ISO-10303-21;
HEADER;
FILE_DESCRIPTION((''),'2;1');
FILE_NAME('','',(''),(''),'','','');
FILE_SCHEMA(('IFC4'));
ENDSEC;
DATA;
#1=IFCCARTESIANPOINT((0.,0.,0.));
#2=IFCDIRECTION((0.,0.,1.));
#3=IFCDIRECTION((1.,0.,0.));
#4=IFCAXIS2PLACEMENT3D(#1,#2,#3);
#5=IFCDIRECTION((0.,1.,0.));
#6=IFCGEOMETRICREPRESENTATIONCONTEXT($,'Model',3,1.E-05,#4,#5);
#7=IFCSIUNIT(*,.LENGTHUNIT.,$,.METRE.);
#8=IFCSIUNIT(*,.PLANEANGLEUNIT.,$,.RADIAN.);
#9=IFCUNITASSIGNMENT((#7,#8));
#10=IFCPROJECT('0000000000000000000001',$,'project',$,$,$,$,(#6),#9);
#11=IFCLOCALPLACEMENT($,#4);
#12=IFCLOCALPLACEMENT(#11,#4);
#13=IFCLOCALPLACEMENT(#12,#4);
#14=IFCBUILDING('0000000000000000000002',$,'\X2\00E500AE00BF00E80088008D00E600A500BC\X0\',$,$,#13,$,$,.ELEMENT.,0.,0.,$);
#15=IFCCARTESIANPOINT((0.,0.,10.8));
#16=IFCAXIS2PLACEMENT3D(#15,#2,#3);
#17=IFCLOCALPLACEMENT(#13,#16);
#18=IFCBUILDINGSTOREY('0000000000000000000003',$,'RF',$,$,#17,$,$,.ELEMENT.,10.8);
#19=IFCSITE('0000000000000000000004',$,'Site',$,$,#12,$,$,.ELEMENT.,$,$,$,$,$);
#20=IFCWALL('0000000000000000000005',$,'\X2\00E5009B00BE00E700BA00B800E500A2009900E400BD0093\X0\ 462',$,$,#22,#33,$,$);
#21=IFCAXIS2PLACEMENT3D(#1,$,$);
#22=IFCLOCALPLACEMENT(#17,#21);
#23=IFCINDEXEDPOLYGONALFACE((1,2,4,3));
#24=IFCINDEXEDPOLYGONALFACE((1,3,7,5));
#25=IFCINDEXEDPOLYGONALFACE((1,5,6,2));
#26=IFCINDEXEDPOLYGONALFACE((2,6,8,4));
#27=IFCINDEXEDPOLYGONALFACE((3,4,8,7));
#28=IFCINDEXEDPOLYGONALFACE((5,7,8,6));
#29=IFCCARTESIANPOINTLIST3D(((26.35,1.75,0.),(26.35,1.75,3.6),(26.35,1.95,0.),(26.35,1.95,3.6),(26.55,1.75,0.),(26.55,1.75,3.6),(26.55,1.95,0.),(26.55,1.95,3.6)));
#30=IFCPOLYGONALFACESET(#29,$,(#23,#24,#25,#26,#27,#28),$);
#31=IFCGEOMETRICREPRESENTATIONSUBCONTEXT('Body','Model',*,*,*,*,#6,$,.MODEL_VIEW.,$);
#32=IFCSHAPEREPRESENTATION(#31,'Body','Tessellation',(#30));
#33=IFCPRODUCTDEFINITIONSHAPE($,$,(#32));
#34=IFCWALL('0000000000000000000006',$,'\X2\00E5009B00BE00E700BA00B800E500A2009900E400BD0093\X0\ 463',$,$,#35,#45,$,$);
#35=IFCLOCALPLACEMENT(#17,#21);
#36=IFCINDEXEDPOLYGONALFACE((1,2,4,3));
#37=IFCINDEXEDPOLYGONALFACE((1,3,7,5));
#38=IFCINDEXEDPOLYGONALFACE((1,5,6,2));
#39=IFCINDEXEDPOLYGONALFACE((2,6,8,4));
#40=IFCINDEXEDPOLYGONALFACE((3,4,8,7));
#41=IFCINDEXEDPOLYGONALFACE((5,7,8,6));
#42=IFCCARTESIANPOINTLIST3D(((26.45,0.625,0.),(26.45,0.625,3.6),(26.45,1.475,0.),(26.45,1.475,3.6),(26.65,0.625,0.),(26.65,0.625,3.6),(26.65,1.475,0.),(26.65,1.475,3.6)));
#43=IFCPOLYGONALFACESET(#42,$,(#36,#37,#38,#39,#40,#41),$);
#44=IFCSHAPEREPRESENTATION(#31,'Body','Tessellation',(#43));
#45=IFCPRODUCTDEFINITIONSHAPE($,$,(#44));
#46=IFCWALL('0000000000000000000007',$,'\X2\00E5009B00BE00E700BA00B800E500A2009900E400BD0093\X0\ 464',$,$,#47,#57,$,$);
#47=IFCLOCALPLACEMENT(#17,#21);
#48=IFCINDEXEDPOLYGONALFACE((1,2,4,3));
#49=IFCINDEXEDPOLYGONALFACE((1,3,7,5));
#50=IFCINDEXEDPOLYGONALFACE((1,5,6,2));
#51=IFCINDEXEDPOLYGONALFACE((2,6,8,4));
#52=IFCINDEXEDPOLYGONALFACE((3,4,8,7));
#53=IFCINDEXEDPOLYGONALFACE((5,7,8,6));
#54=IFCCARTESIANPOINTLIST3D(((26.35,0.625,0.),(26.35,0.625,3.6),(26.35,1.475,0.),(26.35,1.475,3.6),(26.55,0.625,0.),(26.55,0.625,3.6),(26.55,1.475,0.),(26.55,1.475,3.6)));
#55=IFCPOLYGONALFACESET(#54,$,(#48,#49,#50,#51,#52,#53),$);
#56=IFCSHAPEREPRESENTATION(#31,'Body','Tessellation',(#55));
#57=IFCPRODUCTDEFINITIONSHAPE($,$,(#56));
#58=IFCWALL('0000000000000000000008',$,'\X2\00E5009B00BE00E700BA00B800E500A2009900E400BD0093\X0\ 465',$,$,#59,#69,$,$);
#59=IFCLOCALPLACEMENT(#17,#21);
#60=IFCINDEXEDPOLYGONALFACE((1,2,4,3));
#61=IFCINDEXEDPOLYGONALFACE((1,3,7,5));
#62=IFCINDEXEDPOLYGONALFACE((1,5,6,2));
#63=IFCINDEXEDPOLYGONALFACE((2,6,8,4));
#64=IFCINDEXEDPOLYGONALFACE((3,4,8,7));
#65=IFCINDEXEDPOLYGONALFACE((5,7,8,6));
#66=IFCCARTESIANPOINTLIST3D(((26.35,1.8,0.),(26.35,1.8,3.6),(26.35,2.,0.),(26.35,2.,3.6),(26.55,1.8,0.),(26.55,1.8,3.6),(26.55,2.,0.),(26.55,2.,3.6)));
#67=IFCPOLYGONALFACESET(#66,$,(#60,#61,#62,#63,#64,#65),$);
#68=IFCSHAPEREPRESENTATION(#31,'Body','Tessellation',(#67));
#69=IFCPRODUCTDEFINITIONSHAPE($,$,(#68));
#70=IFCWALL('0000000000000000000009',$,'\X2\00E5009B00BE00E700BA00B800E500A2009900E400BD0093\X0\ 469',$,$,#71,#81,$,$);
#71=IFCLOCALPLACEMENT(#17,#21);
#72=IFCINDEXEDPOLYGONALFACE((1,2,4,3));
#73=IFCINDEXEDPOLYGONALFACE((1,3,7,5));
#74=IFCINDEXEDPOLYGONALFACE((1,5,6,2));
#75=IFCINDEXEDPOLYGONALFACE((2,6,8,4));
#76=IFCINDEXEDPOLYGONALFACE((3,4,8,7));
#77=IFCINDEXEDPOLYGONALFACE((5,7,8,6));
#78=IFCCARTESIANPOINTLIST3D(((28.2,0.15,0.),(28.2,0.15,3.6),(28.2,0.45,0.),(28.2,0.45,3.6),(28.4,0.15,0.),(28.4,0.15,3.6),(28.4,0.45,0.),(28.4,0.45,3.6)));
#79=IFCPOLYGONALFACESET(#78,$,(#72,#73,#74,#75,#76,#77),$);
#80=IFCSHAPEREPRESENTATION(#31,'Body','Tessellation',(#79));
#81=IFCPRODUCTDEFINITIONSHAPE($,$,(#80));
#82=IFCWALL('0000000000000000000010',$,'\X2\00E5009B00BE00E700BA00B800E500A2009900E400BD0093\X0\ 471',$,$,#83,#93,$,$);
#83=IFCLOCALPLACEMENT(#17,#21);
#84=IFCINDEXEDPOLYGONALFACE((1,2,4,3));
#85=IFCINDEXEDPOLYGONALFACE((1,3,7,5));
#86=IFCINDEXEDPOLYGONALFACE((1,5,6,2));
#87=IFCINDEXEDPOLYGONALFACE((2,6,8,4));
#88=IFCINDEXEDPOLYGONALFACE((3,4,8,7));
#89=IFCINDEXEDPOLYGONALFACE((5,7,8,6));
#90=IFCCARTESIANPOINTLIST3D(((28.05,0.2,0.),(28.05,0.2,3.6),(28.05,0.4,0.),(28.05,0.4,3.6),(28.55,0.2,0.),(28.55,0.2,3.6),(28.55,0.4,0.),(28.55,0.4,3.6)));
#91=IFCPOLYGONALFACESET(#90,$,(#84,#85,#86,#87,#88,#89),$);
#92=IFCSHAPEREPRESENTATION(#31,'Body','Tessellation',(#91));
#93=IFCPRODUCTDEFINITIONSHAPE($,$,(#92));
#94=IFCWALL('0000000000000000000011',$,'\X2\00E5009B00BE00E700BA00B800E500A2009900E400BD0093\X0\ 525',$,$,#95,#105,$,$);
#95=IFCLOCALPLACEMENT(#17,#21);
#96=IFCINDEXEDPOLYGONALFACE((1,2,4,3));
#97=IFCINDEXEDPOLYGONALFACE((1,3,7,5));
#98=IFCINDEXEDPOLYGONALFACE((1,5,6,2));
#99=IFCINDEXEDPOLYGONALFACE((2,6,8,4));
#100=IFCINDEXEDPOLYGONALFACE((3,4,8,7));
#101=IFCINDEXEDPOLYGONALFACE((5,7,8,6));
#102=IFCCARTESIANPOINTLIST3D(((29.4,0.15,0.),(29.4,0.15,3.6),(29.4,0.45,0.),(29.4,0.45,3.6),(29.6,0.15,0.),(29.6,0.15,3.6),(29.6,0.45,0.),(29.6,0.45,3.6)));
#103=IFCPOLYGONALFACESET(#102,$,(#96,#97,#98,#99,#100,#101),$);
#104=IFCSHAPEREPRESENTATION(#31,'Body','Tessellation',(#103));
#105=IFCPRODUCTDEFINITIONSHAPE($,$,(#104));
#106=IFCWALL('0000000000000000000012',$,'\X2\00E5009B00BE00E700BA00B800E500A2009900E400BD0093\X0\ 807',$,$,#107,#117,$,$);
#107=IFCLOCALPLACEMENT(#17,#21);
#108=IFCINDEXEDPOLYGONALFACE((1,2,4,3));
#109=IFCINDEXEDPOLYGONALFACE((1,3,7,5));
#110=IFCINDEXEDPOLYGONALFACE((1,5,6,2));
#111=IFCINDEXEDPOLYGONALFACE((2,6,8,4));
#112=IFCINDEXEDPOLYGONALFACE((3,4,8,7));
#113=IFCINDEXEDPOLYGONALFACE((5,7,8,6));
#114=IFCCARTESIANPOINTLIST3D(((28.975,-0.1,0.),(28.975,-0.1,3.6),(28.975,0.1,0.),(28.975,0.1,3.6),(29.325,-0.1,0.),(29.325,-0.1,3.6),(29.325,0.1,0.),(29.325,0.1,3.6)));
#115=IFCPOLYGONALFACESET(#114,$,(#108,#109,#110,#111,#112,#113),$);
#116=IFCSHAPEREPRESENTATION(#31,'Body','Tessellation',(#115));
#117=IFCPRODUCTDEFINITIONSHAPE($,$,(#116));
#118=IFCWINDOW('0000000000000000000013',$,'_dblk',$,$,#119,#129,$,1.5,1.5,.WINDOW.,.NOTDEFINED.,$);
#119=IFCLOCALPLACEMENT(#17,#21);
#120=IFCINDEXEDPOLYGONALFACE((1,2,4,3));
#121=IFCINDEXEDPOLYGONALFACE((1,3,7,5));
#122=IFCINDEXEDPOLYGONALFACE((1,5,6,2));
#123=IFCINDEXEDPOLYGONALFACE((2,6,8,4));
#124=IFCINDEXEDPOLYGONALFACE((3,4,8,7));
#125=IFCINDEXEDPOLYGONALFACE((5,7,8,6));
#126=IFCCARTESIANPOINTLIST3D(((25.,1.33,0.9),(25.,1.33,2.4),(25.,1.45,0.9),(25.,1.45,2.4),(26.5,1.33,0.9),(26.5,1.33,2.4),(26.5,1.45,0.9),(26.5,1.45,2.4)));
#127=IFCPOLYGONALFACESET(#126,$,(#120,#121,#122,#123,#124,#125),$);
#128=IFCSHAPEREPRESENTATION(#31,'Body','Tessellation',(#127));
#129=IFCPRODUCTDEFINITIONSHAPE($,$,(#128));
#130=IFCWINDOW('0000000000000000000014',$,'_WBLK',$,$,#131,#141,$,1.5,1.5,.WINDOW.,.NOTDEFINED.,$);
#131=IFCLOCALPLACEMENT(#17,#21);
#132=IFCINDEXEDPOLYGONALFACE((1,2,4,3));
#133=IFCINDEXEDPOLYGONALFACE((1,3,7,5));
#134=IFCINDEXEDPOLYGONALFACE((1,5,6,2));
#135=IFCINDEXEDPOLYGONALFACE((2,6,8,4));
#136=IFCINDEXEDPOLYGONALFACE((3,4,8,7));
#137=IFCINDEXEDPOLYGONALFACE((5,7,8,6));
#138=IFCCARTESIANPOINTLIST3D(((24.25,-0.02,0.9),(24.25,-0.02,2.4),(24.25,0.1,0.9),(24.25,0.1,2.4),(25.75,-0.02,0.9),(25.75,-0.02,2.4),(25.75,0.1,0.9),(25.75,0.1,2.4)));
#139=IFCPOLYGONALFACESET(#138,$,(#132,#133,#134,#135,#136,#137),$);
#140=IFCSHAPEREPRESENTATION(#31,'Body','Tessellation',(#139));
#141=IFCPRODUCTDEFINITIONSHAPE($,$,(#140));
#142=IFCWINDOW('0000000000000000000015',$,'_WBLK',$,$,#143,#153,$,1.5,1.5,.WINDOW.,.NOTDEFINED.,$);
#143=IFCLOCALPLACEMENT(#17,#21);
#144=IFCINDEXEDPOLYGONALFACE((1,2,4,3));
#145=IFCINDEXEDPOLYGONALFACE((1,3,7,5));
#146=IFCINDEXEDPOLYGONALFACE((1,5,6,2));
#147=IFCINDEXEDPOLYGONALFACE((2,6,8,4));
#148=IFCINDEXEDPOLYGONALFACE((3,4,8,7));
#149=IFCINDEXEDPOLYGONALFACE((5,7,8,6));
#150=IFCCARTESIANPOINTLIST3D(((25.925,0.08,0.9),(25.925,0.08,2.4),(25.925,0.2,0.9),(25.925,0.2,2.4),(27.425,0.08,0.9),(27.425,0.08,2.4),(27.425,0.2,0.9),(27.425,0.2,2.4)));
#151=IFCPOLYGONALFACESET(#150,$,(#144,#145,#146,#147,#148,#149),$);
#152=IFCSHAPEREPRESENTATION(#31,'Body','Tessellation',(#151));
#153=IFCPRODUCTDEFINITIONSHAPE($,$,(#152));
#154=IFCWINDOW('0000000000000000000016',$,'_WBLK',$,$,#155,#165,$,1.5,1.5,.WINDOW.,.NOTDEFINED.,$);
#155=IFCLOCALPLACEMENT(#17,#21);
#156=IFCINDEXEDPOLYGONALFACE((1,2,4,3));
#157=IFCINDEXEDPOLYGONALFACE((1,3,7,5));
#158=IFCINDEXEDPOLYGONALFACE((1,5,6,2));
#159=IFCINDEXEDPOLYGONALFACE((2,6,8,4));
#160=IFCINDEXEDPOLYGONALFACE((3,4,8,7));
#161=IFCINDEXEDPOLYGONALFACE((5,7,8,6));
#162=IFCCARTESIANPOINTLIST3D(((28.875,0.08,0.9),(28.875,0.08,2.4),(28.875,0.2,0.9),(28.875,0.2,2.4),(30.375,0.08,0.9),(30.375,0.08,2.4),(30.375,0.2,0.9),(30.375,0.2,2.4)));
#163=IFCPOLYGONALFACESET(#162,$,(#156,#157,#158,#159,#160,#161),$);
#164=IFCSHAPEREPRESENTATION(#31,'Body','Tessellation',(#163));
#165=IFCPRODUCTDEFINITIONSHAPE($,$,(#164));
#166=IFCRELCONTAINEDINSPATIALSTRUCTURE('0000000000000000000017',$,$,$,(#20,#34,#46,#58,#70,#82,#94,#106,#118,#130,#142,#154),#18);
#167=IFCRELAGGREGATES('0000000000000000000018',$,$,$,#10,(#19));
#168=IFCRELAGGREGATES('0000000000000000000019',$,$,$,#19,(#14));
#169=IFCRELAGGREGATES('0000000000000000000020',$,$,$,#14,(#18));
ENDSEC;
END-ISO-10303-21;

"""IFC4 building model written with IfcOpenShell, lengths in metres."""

from ifc_helpers import new_model, si_unit, direction, frame, frame_2d, origin_with_axes, place, context, subcontext, project, spatial, rectangle, extrude, element, save


model = new_model("IFC4")

# Units and contexts
model_context = context("Model", 3, precision=1e-05, world=origin_with_axes(), true_north=direction((0.0, 1.0, 0.0)))
body_context = subcontext(model_context, "Body", "Model", "MODEL_VIEW")
ifc_project = project(units=[si_unit("LENGTHUNIT", "METRE"), si_unit("PLANEANGLEUNIT", "RADIAN")], contexts=[model_context])

# Site, building, storey
placement = place(None, origin_with_axes())
site_placement = place(placement, origin_with_axes())
site = spatial("IfcSite", under=ifc_project, at=site_placement, Name="Site", CompositionType="ELEMENT")
building_placement = place(site_placement, origin_with_axes())
building = spatial("IfcBuilding", under=site, at=building_placement, Name="å®¿è\u0088\u008dæ¥¼", CompositionType="ELEMENT", ElevationOfRefHeight=0.0, ElevationOfTerrain=0.0)
storey_placement = place(building_placement, frame((0.0, 0.0, 10.8), z_axis=(0.0, 0.0, 1.0), x_axis=(1.0, 0.0, 0.0)))
storey = spatial("IfcBuildingStorey", under=building, at=storey_placement, Name="RF", CompositionType="ELEMENT", Elevation=10.8)

# Walls
for number, where, z_axis, x_axis, name in (
    (1, (26.45, 1.85, 0.0), (0.0, 0.0, 1.0), (1.0, 0.0, 0.0), "å\u009b¾çº¸å¢\u0099ä½\u0093 462"),
):
    element("IfcWall", number, at=place(storey_placement, frame(where, z_axis=z_axis, x_axis=x_axis)), inside=storey, Name=name, context=body_context, shape_type="SweptSolid", body=[
        extrude(rectangle(XDim=0.2, YDim=0.2, at=frame_2d((0.0, 0.0), x_axis=(1.0, 0.0, 0.0))), frame((0.0, 0.0, 0.0), z_axis=(0.0, 0.0, 1.0)), (0.0, 0.0, 1.0), 3.6),
    ])
for number, where, z_axis, x_axis, name in (
    (2, (26.55, 1.05, 0.0), (0.0, 0.0, 1.0), (0.0, -1.0, 0.0), "å\u009b¾çº¸å¢\u0099ä½\u0093 463"),
    (3, (26.45, 1.05, 0.0), (0.0, 0.0, 1.0), (0.0, -1.0, 0.0), "å\u009b¾çº¸å¢\u0099ä½\u0093 464"),
):
    element("IfcWall", number, at=place(storey_placement, frame(where, z_axis=z_axis, x_axis=x_axis)), inside=storey, Name=name, context=body_context, shape_type="SweptSolid", body=[
        extrude(rectangle(XDim=0.85, YDim=0.2, at=frame_2d((0.0, 0.0), x_axis=(1.0, 0.0, 0.0))), frame((0.0, 0.0, 0.0), z_axis=(0.0, 0.0, 1.0)), (0.0, 0.0, 1.0), 3.6),
    ])
wall_1_placement = place(storey_placement, frame((26.45, 1.9, 0.0), z_axis=(0.0, 0.0, 1.0), x_axis=(0.0, -1.0, 0.0)))
element("IfcWall", 4, at=wall_1_placement, inside=storey, Name="å\u009b¾çº¸å¢\u0099ä½\u0093 465", context=body_context, shape_type="SweptSolid", body=[
    extrude(rectangle(XDim=0.2, YDim=0.2, at=frame_2d((0.0, 0.0), x_axis=(1.0, 0.0, 0.0))), frame((0.0, 0.0, 0.0), z_axis=(0.0, 0.0, 1.0)), (0.0, 0.0, 1.0), 3.6),
])
wall_2_placement = place(storey_placement, frame((28.3, 0.3, 0.0), z_axis=(0.0, 0.0, 1.0), x_axis=(0.0, -1.0, 0.0)))
element("IfcWall", 5, at=wall_2_placement, inside=storey, Name="å\u009b¾çº¸å¢\u0099ä½\u0093 469", context=body_context, shape_type="SweptSolid", body=[
    extrude(rectangle(XDim=0.3, YDim=0.2, at=frame_2d((0.0, 0.0), x_axis=(1.0, 0.0, 0.0))), frame((0.0, 0.0, 0.0), z_axis=(0.0, 0.0, 1.0)), (0.0, 0.0, 1.0), 3.6),
])
wall_3_placement = place(storey_placement, frame((28.3, 0.3, 0.0), z_axis=(0.0, 0.0, 1.0), x_axis=(1.0, 0.0, 0.0)))
element("IfcWall", 6, at=wall_3_placement, inside=storey, Name="å\u009b¾çº¸å¢\u0099ä½\u0093 471", context=body_context, shape_type="SweptSolid", body=[
    extrude(rectangle(XDim=0.5, YDim=0.2, at=frame_2d((0.0, 0.0), x_axis=(1.0, 0.0, 0.0))), frame((0.0, 0.0, 0.0), z_axis=(0.0, 0.0, 1.0)), (0.0, 0.0, 1.0), 3.6),
])
wall_4_placement = place(storey_placement, frame((29.5, 0.3, 0.0), z_axis=(0.0, 0.0, 1.0), x_axis=(0.0, -1.0, 0.0)))
element("IfcWall", 7, at=wall_4_placement, inside=storey, Name="å\u009b¾çº¸å¢\u0099ä½\u0093 525", context=body_context, shape_type="SweptSolid", body=[
    extrude(rectangle(XDim=0.3, YDim=0.2, at=frame_2d((0.0, 0.0), x_axis=(1.0, 0.0, 0.0))), frame((0.0, 0.0, 0.0), z_axis=(0.0, 0.0, 1.0)), (0.0, 0.0, 1.0), 3.6),
])
wall_5_placement = place(storey_placement, frame((29.15, 0.0, 0.0), z_axis=(0.0, 0.0, 1.0), x_axis=(1.0, 0.0, 0.0)))
element("IfcWall", 8, at=wall_5_placement, inside=storey, Name="å\u009b¾çº¸å¢\u0099ä½\u0093 807", context=body_context, shape_type="SweptSolid", body=[
    extrude(rectangle(XDim=0.35, YDim=0.2, at=frame_2d((0.0, 0.0), x_axis=(1.0, 0.0, 0.0))), frame((0.0, 0.0, 0.0), z_axis=(0.0, 0.0, 1.0)), (0.0, 0.0, 1.0), 3.6),
])

# Windows
for number, where, z_axis, x_axis, name in (
    (9, (25.75, 1.39, 0.9), (0.0, 0.0, 1.0), (1.0, 0.0, 0.0), "_dblk"),
    (10, (25.0, 0.04, 0.9), (0.0, 0.0, 1.0), (1.0, 0.0, 0.0), "_WBLK"),
    (11, (26.675, 0.14, 0.9), (0.0, 0.0, 1.0), (1.0, 0.0, 0.0), "_WBLK"),
    (12, (29.625, 0.14, 0.9), (0.0, 0.0, 1.0), (1.0, 0.0, 0.0), "_WBLK"),
):
    element("IfcWindow", number, at=place(storey_placement, frame(where, z_axis=z_axis, x_axis=x_axis)), inside=storey, Name=name, OverallHeight=1.5, OverallWidth=1.5, PartitioningType="NOTDEFINED", PredefinedType="WINDOW", context=body_context, shape_type="SweptSolid", body=[
        extrude(rectangle(XDim=1.5, YDim=0.12, at=frame_2d((0.0, 0.0), x_axis=(1.0, 0.0, 0.0))), frame((0.0, 0.0, 0.0), z_axis=(0.0, 0.0, 1.0)), (0.0, 0.0, 1.0), 1.5),
    ])

save(model, "model.ifc")
